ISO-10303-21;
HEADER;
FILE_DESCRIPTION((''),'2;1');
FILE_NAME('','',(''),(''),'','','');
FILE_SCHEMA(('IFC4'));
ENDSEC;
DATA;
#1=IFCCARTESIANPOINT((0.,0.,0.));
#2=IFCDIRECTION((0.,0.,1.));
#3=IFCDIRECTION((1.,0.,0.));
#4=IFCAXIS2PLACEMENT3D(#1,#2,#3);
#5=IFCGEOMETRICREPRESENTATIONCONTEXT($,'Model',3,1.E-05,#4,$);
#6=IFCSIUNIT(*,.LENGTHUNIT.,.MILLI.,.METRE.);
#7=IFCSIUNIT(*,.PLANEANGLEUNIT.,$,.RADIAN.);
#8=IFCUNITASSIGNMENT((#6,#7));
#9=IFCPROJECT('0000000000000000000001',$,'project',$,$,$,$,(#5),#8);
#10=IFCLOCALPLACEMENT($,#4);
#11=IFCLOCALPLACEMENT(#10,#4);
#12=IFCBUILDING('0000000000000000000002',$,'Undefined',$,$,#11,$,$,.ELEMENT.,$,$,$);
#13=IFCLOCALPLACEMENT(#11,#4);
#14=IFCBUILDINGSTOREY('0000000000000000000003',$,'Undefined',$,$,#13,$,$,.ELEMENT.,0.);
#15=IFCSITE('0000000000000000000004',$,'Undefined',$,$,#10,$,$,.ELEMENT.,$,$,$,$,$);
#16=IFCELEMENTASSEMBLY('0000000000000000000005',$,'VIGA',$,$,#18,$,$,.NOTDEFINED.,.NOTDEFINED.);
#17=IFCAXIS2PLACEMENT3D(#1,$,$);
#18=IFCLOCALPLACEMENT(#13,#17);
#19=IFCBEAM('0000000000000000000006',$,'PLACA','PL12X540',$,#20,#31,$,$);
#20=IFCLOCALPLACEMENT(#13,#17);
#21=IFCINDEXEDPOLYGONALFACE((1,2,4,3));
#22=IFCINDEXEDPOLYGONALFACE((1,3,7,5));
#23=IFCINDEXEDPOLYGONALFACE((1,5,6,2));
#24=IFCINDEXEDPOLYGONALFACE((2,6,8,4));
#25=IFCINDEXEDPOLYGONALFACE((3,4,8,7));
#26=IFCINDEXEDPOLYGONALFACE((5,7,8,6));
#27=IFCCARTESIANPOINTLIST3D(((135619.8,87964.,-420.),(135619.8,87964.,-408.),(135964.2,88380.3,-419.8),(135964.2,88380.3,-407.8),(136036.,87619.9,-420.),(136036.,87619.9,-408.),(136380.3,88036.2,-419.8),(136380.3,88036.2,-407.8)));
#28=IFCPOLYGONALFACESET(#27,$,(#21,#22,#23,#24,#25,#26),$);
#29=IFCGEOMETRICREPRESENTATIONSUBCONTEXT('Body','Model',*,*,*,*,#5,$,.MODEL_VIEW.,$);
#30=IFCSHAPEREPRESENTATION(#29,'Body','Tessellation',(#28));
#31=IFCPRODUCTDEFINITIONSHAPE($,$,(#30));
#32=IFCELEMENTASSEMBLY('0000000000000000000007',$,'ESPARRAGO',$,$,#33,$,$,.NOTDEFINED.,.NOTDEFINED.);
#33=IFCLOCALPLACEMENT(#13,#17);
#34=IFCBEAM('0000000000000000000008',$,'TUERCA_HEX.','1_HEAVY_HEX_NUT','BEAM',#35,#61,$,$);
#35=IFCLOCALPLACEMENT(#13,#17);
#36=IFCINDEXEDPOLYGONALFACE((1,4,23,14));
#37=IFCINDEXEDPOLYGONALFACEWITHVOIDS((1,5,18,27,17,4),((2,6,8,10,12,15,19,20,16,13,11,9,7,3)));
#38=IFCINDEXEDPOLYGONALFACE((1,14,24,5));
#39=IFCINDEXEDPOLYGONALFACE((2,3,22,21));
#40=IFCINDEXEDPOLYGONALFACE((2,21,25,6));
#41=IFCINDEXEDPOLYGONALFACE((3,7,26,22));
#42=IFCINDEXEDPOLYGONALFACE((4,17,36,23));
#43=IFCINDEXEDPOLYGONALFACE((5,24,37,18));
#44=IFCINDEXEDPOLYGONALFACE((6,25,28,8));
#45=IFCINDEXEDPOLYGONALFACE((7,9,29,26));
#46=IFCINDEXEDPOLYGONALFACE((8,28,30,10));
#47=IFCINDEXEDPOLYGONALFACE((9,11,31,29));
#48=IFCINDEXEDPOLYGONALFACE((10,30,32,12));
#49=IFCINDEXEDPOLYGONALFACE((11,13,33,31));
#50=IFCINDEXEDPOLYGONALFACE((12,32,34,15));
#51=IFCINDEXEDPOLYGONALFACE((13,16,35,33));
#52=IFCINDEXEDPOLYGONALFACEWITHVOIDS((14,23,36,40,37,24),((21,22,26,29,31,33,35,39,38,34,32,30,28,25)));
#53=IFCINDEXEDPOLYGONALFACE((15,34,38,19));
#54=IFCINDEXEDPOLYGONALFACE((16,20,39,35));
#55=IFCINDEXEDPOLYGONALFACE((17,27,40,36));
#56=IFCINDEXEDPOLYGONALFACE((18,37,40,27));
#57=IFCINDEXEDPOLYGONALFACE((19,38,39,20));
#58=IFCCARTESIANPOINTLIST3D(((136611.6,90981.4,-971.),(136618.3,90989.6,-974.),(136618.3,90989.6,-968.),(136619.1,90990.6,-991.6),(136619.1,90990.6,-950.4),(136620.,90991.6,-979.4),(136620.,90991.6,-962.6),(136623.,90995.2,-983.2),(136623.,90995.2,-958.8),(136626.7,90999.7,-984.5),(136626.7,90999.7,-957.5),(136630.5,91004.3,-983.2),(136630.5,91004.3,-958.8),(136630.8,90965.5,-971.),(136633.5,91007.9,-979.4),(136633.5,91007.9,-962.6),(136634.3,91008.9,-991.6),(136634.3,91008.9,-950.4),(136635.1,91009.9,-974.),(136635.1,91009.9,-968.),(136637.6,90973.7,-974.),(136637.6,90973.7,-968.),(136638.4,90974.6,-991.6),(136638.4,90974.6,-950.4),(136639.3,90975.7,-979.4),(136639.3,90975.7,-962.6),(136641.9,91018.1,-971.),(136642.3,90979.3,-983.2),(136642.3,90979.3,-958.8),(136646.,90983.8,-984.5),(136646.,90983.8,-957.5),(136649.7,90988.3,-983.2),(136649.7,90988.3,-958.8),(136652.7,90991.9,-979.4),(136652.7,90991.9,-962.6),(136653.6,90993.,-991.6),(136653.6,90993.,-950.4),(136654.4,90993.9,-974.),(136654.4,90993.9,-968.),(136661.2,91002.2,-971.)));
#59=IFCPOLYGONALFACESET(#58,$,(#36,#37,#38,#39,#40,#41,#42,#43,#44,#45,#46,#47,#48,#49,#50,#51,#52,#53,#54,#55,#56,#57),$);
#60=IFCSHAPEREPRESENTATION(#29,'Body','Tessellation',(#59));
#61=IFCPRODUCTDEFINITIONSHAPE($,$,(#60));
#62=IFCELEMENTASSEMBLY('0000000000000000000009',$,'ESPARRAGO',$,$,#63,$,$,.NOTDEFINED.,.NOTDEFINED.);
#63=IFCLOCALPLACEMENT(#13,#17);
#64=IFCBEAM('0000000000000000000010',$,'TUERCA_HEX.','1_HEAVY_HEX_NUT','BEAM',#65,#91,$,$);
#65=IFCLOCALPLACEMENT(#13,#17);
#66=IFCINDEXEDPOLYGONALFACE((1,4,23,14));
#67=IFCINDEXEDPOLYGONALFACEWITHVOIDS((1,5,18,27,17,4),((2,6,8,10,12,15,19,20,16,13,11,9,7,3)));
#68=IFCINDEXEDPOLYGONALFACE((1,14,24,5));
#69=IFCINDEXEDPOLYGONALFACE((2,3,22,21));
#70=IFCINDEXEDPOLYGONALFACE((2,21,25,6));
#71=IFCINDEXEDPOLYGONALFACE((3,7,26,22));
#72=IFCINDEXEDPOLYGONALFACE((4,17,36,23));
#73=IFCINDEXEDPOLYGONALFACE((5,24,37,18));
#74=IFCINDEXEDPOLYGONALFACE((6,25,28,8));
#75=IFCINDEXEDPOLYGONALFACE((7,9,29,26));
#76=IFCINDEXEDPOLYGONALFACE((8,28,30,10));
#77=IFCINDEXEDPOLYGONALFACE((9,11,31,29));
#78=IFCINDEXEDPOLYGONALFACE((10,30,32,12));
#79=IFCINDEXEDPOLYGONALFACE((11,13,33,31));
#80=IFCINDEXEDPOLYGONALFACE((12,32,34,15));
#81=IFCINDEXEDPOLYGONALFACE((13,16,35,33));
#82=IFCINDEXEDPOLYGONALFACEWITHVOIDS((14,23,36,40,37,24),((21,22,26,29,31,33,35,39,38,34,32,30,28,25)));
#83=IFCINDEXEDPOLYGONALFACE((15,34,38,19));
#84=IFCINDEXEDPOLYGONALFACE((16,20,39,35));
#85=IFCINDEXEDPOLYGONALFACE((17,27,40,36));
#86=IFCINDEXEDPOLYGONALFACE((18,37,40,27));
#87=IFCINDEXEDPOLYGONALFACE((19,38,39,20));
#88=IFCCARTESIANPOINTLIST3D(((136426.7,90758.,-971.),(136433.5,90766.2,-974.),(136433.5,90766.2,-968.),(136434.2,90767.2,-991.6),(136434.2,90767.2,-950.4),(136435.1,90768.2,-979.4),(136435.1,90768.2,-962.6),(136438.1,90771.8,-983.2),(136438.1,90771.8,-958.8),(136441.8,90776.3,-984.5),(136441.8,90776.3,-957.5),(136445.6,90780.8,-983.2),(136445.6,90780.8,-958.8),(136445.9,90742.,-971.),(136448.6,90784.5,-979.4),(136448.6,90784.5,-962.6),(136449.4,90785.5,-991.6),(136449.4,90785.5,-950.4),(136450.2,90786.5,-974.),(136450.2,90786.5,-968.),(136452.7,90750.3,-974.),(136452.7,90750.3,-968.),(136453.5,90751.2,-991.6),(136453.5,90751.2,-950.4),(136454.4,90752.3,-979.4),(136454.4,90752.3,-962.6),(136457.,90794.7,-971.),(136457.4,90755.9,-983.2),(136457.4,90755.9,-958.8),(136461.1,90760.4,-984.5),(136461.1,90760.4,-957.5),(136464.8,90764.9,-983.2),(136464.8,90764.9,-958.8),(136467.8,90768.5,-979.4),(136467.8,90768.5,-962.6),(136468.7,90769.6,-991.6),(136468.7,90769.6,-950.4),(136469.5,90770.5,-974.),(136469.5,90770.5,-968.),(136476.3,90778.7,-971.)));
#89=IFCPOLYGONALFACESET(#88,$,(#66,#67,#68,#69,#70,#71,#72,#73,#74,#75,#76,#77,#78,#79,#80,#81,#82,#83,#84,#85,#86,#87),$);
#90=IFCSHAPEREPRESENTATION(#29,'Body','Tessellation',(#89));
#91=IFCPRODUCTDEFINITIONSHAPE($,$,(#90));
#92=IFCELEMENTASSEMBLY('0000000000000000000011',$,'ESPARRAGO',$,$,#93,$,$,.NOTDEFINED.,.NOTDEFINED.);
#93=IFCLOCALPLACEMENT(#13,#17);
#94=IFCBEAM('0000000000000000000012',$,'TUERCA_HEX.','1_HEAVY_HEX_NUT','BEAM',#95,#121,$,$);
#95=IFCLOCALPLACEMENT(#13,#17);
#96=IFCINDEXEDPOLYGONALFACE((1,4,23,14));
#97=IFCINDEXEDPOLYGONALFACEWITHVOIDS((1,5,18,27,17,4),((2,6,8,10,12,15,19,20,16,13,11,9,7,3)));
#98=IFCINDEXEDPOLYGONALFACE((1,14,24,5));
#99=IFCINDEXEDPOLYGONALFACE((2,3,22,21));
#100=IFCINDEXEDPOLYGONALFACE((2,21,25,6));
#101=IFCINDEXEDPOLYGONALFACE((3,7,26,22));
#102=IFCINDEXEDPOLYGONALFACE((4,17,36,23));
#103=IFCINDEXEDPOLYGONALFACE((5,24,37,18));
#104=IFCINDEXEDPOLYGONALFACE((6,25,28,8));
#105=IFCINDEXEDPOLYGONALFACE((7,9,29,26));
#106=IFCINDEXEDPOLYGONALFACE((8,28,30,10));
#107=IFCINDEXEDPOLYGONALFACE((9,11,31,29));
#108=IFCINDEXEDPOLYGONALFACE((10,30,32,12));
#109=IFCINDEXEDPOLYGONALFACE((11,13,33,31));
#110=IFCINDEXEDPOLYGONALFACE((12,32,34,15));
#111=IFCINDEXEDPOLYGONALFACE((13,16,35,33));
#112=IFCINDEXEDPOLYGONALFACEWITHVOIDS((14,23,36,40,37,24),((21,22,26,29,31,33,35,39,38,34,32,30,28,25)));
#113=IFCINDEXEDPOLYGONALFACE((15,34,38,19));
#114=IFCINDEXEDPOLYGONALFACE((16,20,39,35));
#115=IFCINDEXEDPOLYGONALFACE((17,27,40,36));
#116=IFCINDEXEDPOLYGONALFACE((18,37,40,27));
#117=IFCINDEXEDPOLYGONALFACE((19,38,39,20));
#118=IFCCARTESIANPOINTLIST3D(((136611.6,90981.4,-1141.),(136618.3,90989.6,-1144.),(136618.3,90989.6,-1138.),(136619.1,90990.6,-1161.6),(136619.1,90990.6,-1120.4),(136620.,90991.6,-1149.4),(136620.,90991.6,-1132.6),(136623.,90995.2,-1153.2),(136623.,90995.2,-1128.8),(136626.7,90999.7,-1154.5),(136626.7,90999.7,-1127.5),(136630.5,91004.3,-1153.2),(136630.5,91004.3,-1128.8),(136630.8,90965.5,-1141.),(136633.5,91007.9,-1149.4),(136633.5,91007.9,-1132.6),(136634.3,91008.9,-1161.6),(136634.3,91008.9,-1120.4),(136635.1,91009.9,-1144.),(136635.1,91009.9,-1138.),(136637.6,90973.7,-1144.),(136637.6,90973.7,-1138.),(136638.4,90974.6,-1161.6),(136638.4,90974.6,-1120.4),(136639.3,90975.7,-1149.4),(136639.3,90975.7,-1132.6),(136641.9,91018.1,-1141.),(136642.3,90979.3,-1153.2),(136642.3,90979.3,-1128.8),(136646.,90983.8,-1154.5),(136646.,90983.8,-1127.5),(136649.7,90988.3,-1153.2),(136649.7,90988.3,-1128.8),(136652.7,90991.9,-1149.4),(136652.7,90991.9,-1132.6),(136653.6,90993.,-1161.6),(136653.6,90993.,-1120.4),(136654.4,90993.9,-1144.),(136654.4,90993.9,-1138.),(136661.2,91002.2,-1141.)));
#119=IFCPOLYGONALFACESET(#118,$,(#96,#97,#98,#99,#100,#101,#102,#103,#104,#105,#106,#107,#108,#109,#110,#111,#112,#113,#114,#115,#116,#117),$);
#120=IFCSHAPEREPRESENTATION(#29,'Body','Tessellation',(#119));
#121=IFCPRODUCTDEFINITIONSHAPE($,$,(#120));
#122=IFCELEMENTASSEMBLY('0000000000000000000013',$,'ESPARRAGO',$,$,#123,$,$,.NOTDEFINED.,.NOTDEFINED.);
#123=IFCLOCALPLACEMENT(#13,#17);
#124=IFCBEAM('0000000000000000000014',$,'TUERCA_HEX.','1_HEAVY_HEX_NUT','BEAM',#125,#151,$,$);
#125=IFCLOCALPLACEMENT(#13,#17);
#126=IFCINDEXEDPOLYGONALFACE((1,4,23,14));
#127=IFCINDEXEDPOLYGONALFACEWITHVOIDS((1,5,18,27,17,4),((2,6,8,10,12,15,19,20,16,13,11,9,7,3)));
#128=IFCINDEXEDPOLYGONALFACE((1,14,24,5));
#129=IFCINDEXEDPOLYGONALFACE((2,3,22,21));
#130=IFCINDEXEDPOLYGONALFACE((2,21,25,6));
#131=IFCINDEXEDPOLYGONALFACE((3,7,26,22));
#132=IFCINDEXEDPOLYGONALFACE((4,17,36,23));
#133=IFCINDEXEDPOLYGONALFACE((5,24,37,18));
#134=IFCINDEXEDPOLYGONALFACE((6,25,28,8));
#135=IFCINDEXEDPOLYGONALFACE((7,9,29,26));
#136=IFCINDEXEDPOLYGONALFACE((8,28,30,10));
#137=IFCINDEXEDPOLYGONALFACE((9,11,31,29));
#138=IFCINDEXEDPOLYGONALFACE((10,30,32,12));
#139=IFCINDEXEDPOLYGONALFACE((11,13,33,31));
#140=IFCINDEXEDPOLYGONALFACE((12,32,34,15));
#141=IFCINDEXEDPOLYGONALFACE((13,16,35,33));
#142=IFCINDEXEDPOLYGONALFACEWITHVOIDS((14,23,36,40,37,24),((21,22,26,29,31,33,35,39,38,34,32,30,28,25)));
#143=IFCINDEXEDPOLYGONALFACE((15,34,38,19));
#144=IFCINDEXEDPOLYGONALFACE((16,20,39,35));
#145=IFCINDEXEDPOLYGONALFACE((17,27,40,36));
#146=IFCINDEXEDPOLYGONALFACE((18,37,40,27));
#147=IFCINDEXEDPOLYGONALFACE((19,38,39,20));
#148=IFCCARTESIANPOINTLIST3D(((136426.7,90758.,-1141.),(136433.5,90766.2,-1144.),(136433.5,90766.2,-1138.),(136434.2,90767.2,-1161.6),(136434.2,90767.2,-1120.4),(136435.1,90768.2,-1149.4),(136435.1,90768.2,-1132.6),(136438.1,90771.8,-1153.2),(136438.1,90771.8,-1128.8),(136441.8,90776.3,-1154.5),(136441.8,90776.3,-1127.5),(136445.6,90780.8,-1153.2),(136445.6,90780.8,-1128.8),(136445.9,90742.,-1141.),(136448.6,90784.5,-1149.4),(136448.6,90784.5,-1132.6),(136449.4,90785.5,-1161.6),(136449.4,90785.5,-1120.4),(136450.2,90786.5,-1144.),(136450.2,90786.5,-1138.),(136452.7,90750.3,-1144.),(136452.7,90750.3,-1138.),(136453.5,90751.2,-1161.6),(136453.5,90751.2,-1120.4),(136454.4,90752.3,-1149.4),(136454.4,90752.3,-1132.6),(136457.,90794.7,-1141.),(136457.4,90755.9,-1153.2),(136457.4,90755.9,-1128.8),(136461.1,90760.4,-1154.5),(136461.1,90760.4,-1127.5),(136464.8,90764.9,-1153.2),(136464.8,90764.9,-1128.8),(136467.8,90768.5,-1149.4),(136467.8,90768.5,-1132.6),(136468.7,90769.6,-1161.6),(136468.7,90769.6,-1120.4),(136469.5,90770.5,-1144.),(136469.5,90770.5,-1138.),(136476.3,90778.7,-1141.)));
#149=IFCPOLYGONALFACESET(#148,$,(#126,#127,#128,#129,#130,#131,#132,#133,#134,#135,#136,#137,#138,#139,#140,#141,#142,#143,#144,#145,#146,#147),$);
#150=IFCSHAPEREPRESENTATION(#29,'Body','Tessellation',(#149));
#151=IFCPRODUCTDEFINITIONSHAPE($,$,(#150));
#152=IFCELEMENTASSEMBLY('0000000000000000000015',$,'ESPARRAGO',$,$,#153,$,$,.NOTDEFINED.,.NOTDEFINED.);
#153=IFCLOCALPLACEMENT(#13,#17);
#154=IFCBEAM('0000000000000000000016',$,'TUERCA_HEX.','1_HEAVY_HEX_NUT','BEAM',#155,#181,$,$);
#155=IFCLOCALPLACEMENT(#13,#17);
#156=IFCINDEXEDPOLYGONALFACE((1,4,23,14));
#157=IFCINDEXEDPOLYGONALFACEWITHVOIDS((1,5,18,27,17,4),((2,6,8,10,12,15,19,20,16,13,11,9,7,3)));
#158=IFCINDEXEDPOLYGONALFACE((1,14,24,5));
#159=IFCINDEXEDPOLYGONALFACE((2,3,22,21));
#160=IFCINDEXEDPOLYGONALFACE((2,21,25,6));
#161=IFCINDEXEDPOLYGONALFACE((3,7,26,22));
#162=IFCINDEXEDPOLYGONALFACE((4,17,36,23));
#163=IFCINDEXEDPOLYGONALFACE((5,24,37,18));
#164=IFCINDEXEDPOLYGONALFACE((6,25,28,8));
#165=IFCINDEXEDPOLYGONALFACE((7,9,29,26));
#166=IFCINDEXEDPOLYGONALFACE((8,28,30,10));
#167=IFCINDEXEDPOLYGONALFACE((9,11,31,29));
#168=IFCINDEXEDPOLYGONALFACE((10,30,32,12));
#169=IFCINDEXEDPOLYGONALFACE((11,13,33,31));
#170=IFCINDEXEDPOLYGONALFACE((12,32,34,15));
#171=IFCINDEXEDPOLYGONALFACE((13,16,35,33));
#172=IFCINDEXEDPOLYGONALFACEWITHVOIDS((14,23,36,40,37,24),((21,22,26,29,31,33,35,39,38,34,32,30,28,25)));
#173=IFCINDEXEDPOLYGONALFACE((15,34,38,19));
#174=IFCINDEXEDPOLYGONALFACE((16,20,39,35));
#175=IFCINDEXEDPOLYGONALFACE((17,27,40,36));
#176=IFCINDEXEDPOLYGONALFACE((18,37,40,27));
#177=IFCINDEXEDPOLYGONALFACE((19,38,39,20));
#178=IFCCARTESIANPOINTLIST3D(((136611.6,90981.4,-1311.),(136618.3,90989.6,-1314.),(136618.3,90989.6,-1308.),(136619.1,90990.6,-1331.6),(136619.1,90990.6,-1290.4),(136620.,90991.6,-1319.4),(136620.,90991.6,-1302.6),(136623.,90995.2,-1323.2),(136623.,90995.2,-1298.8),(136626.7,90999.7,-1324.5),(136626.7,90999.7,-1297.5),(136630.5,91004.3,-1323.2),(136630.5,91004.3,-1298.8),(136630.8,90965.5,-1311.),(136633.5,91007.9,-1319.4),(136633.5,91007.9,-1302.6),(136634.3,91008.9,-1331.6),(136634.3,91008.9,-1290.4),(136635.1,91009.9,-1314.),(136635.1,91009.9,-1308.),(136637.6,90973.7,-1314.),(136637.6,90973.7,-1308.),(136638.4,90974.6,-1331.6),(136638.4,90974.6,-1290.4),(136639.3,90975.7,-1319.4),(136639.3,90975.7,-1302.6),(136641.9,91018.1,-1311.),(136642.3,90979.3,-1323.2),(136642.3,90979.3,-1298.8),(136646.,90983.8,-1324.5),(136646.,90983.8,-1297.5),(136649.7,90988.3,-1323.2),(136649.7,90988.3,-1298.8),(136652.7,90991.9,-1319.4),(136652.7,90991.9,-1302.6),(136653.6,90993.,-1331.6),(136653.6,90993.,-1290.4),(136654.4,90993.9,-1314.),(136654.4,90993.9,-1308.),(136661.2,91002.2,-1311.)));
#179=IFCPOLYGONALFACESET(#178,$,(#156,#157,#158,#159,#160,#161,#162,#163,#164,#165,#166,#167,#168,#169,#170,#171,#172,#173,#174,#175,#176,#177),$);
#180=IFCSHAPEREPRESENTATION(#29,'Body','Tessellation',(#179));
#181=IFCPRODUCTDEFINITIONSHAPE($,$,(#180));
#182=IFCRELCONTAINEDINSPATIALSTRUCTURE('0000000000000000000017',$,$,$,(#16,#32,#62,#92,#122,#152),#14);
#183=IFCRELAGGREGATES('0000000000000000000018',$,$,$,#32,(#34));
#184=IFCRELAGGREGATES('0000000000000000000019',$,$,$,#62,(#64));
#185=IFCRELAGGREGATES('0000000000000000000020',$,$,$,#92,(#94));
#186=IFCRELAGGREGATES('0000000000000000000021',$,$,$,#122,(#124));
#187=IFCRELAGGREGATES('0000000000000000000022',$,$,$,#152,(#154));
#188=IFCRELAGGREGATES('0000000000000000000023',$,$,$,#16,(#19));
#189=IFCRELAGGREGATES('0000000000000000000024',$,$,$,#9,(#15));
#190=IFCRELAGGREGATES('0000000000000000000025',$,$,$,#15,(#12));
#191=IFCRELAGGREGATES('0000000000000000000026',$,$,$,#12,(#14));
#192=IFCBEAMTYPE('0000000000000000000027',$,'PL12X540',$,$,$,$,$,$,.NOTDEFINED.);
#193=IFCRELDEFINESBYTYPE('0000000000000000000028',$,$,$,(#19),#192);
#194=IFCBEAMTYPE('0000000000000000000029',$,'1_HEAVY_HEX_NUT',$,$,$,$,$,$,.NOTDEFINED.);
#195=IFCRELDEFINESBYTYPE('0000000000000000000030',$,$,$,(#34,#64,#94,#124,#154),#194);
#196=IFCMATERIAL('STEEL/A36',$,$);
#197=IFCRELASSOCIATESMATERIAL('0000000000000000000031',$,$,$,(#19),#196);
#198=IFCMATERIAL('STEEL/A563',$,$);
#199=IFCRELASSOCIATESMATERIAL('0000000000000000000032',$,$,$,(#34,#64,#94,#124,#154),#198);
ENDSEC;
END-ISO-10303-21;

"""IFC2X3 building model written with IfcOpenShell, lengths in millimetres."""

from ifc_helpers import new_model, si_unit, frame, origin_with_axes, origin_2d_with_axis, place, context, subcontext, project, spatial, polyline, rectangle, outline, extrude, material, type_object, element, aggregate, save


model = new_model("IFC2X3")

# Units and contexts
model_context = context("Model", 3, precision=1e-05, world=origin_with_axes())
body_context = subcontext(model_context, "Body", "Model", "MODEL_VIEW")
ifc_project = project(units=[si_unit("LENGTHUNIT", "METRE", prefix="MILLI"), si_unit("PLANEANGLEUNIT", "RADIAN")], contexts=[model_context])

# Site, building, storey
site_placement = place(None, origin_with_axes())
site = spatial("IfcSite", under=ifc_project, at=site_placement, Name="Undefined", CompositionType="ELEMENT")
building_placement = place(site_placement, origin_with_axes())
building = spatial("IfcBuilding", under=site, at=building_placement, Name="Undefined", CompositionType="ELEMENT")
storey_placement = place(building_placement, origin_with_axes())
storey = spatial("IfcBuildingStorey", under=building, at=storey_placement, Name="Undefined", CompositionType="ELEMENT", Elevation=0.0)

# Element assemblies, beams
assembly_1_placement = place(storey_placement, origin_with_axes())
assembly_1 = element("IfcElementAssembly", 1, at=assembly_1_placement, inside=storey, Name="VIGA", AssemblyPlace="NOTDEFINED", PredefinedType="NOTDEFINED")
ifc_material_1 = material(Name="STEEL/A36")
beam_type_1 = type_object("IfcBeamType", Name="PL12X540", PredefinedType="NOTDEFINED")
beam_1_placement = place(assembly_1_placement, frame((135827.9, 87791.9, -414.0), z_axis=(-0.770596, 0.637324, 0.0), x_axis=(0.637324, 0.770596, 0.000333)))
beam_1 = element("IfcBeam", 2, at=beam_1_placement, type_object=beam_type_1, material=ifc_material_1, Name="PLACA", Description="PL12X540", context=body_context, shape_type="SweptSolid", body=[
    extrude(rectangle(XDim=12.0, YDim=540.0, at=origin_2d_with_axis()), frame((540.3, 0.0, 0.0), z_axis=(-1.0, 0.0, 0.0), x_axis=(0.0, -1.0, 0.0)), (0.0, 0.0, 1.0), 540.3),
])
assembly_2_placement = place(storey_placement, origin_with_axes())
assembly_2 = element("IfcElementAssembly", 3, at=assembly_2_placement, inside=storey, Name="ESPARRAGO", AssemblyPlace="NOTDEFINED", PredefinedType="NOTDEFINED")
ifc_material_2 = material(Name="STEEL/A563")
beam_type_2 = type_object("IfcBeamType", Name="1_HEAVY_HEX_NUT", PredefinedType="NOTDEFINED")
beam_2_placement = place(assembly_2_placement, frame((136626.7, 90999.7, -971.0), z_axis=(0.000011, -0.000009, 1.0), x_axis=(0.770401, -0.63756, -0.000014)))
beam_2 = element("IfcBeam", 4, at=beam_2_placement, type_object=beam_type_2, material=ifc_material_2, Name="TUERCA_HEX.", Description="1_HEAVY_HEX_NUT", ObjectType="BEAM", context=body_context, shape_type="SweptSolid", body=[
    extrude(outline(polyline([(11.9, -20.6), (-11.9, -20.6), (-23.8, 0.0), (-11.9, 20.6), (11.9, 20.6), (23.8, 0.0), (11.9, -20.6)]), holes=[polyline([(-5.9, 12.2), (-10.5, 8.4), (-13.2, 3.0), (-13.2, -3.0), (-10.5, -8.4), (-5.9, -12.2), (0.0, -13.5), (5.9, -12.2), (10.5, -8.4), (13.2, -3.0), (13.2, 3.0), (10.5, 8.4), (5.9, 12.2), (0.0, 13.5), (-5.9, 12.2)])]), frame((25.0, 0.0, 0.0), z_axis=(-1.0, 0.0, 0.0), x_axis=(0.0, -1.0, 0.0)), (0.0, 0.0, 1.0), 25.0),
])
assembly_3_placement = place(storey_placement, origin_with_axes())
assembly_3 = element("IfcElementAssembly", 5, at=assembly_3_placement, inside=storey, Name="ESPARRAGO", AssemblyPlace="NOTDEFINED", PredefinedType="NOTDEFINED")
beam_3_placement = place(assembly_3_placement, frame((136441.8, 90776.3, -971.0), z_axis=(0.000011, -0.000009, 1.0), x_axis=(0.770401, -0.63756, -0.000014)))
beam_3 = element("IfcBeam", 6, at=beam_3_placement, type_object=beam_type_2, material=ifc_material_2, Name="TUERCA_HEX.", Description="1_HEAVY_HEX_NUT", ObjectType="BEAM", context=body_context, shape_type="SweptSolid", body=[
    extrude(outline(polyline([(11.9, -20.6), (-11.9, -20.6), (-23.8, 0.0), (-11.9, 20.6), (11.9, 20.6), (23.8, 0.0), (11.9, -20.6)]), holes=[polyline([(-5.9, 12.2), (-10.5, 8.4), (-13.2, 3.0), (-13.2, -3.0), (-10.5, -8.4), (-5.9, -12.2), (0.0, -13.5), (5.9, -12.2), (10.5, -8.4), (13.2, -3.0), (13.2, 3.0), (10.5, 8.4), (5.9, 12.2), (0.0, 13.5), (-5.9, 12.2)])]), frame((25.0, 0.0, 0.0), z_axis=(-1.0, 0.0, 0.0), x_axis=(0.0, -1.0, 0.0)), (0.0, 0.0, 1.0), 25.0),
])
assembly_4_placement = place(storey_placement, origin_with_axes())
assembly_4 = element("IfcElementAssembly", 7, at=assembly_4_placement, inside=storey, Name="ESPARRAGO", AssemblyPlace="NOTDEFINED", PredefinedType="NOTDEFINED")
beam_4_placement = place(assembly_4_placement, frame((136626.7, 90999.7, -1141.0), z_axis=(0.000011, -0.000009, 1.0), x_axis=(0.770401, -0.63756, -0.000014)))
beam_4 = element("IfcBeam", 8, at=beam_4_placement, type_object=beam_type_2, material=ifc_material_2, Name="TUERCA_HEX.", Description="1_HEAVY_HEX_NUT", ObjectType="BEAM", context=body_context, shape_type="SweptSolid", body=[
    extrude(outline(polyline([(11.9, -20.6), (-11.9, -20.6), (-23.8, 0.0), (-11.9, 20.6), (11.9, 20.6), (23.8, 0.0), (11.9, -20.6)]), holes=[polyline([(-5.9, 12.2), (-10.5, 8.4), (-13.2, 3.0), (-13.2, -3.0), (-10.5, -8.4), (-5.9, -12.2), (0.0, -13.5), (5.9, -12.2), (10.5, -8.4), (13.2, -3.0), (13.2, 3.0), (10.5, 8.4), (5.9, 12.2), (0.0, 13.5), (-5.9, 12.2)])]), frame((25.0, 0.0, 0.0), z_axis=(-1.0, 0.0, 0.0), x_axis=(0.0, -1.0, 0.0)), (0.0, 0.0, 1.0), 25.0),
])
assembly_5_placement = place(storey_placement, origin_with_axes())
assembly_5 = element("IfcElementAssembly", 9, at=assembly_5_placement, inside=storey, Name="ESPARRAGO", AssemblyPlace="NOTDEFINED", PredefinedType="NOTDEFINED")
beam_5_placement = place(assembly_5_placement, frame((136441.8, 90776.3, -1141.0), z_axis=(0.000011, -0.000009, 1.0), x_axis=(0.770401, -0.63756, -0.000014)))
beam_5 = element("IfcBeam", 10, at=beam_5_placement, type_object=beam_type_2, material=ifc_material_2, Name="TUERCA_HEX.", Description="1_HEAVY_HEX_NUT", ObjectType="BEAM", context=body_context, shape_type="SweptSolid", body=[
    extrude(outline(polyline([(11.9, -20.6), (-11.9, -20.6), (-23.8, 0.0), (-11.9, 20.6), (11.9, 20.6), (23.8, 0.0), (11.9, -20.6)]), holes=[polyline([(-5.9, 12.2), (-10.5, 8.4), (-13.2, 3.0), (-13.2, -3.0), (-10.5, -8.4), (-5.9, -12.2), (0.0, -13.5), (5.9, -12.2), (10.5, -8.4), (13.2, -3.0), (13.2, 3.0), (10.5, 8.4), (5.9, 12.2), (0.0, 13.5), (-5.9, 12.2)])]), frame((25.0, 0.0, 0.0), z_axis=(-1.0, 0.0, 0.0), x_axis=(0.0, -1.0, 0.0)), (0.0, 0.0, 1.0), 25.0),
])
assembly_6_placement = place(storey_placement, origin_with_axes())
assembly_6 = element("IfcElementAssembly", 11, at=assembly_6_placement, inside=storey, Name="ESPARRAGO", AssemblyPlace="NOTDEFINED", PredefinedType="NOTDEFINED")
beam_6_placement = place(assembly_6_placement, frame((136626.7, 90999.7, -1311.0), z_axis=(0.000011, -0.000009, 1.0), x_axis=(0.770401, -0.63756, -0.000014)))
beam_6 = element("IfcBeam", 12, at=beam_6_placement, type_object=beam_type_2, material=ifc_material_2, Name="TUERCA_HEX.", Description="1_HEAVY_HEX_NUT", ObjectType="BEAM", context=body_context, shape_type="SweptSolid", body=[
    extrude(outline(polyline([(11.9, -20.6), (-11.9, -20.6), (-23.8, 0.0), (-11.9, 20.6), (11.9, 20.6), (23.8, 0.0), (11.9, -20.6)]), holes=[polyline([(-5.9, 12.2), (-10.5, 8.4), (-13.2, 3.0), (-13.2, -3.0), (-10.5, -8.4), (-5.9, -12.2), (0.0, -13.5), (5.9, -12.2), (10.5, -8.4), (13.2, -3.0), (13.2, 3.0), (10.5, 8.4), (5.9, 12.2), (0.0, 13.5), (-5.9, 12.2)])]), frame((25.0, 0.0, 0.0), z_axis=(-1.0, 0.0, 0.0), x_axis=(0.0, -1.0, 0.0)), (0.0, 0.0, 1.0), 25.0),
])

aggregate(assembly_2, [beam_2])
aggregate(assembly_3, [beam_3])
aggregate(assembly_4, [beam_4])
aggregate(assembly_5, [beam_5])
aggregate(assembly_6, [beam_6])

aggregate(assembly_1, [beam_1])

save(model, "model.ifc")
